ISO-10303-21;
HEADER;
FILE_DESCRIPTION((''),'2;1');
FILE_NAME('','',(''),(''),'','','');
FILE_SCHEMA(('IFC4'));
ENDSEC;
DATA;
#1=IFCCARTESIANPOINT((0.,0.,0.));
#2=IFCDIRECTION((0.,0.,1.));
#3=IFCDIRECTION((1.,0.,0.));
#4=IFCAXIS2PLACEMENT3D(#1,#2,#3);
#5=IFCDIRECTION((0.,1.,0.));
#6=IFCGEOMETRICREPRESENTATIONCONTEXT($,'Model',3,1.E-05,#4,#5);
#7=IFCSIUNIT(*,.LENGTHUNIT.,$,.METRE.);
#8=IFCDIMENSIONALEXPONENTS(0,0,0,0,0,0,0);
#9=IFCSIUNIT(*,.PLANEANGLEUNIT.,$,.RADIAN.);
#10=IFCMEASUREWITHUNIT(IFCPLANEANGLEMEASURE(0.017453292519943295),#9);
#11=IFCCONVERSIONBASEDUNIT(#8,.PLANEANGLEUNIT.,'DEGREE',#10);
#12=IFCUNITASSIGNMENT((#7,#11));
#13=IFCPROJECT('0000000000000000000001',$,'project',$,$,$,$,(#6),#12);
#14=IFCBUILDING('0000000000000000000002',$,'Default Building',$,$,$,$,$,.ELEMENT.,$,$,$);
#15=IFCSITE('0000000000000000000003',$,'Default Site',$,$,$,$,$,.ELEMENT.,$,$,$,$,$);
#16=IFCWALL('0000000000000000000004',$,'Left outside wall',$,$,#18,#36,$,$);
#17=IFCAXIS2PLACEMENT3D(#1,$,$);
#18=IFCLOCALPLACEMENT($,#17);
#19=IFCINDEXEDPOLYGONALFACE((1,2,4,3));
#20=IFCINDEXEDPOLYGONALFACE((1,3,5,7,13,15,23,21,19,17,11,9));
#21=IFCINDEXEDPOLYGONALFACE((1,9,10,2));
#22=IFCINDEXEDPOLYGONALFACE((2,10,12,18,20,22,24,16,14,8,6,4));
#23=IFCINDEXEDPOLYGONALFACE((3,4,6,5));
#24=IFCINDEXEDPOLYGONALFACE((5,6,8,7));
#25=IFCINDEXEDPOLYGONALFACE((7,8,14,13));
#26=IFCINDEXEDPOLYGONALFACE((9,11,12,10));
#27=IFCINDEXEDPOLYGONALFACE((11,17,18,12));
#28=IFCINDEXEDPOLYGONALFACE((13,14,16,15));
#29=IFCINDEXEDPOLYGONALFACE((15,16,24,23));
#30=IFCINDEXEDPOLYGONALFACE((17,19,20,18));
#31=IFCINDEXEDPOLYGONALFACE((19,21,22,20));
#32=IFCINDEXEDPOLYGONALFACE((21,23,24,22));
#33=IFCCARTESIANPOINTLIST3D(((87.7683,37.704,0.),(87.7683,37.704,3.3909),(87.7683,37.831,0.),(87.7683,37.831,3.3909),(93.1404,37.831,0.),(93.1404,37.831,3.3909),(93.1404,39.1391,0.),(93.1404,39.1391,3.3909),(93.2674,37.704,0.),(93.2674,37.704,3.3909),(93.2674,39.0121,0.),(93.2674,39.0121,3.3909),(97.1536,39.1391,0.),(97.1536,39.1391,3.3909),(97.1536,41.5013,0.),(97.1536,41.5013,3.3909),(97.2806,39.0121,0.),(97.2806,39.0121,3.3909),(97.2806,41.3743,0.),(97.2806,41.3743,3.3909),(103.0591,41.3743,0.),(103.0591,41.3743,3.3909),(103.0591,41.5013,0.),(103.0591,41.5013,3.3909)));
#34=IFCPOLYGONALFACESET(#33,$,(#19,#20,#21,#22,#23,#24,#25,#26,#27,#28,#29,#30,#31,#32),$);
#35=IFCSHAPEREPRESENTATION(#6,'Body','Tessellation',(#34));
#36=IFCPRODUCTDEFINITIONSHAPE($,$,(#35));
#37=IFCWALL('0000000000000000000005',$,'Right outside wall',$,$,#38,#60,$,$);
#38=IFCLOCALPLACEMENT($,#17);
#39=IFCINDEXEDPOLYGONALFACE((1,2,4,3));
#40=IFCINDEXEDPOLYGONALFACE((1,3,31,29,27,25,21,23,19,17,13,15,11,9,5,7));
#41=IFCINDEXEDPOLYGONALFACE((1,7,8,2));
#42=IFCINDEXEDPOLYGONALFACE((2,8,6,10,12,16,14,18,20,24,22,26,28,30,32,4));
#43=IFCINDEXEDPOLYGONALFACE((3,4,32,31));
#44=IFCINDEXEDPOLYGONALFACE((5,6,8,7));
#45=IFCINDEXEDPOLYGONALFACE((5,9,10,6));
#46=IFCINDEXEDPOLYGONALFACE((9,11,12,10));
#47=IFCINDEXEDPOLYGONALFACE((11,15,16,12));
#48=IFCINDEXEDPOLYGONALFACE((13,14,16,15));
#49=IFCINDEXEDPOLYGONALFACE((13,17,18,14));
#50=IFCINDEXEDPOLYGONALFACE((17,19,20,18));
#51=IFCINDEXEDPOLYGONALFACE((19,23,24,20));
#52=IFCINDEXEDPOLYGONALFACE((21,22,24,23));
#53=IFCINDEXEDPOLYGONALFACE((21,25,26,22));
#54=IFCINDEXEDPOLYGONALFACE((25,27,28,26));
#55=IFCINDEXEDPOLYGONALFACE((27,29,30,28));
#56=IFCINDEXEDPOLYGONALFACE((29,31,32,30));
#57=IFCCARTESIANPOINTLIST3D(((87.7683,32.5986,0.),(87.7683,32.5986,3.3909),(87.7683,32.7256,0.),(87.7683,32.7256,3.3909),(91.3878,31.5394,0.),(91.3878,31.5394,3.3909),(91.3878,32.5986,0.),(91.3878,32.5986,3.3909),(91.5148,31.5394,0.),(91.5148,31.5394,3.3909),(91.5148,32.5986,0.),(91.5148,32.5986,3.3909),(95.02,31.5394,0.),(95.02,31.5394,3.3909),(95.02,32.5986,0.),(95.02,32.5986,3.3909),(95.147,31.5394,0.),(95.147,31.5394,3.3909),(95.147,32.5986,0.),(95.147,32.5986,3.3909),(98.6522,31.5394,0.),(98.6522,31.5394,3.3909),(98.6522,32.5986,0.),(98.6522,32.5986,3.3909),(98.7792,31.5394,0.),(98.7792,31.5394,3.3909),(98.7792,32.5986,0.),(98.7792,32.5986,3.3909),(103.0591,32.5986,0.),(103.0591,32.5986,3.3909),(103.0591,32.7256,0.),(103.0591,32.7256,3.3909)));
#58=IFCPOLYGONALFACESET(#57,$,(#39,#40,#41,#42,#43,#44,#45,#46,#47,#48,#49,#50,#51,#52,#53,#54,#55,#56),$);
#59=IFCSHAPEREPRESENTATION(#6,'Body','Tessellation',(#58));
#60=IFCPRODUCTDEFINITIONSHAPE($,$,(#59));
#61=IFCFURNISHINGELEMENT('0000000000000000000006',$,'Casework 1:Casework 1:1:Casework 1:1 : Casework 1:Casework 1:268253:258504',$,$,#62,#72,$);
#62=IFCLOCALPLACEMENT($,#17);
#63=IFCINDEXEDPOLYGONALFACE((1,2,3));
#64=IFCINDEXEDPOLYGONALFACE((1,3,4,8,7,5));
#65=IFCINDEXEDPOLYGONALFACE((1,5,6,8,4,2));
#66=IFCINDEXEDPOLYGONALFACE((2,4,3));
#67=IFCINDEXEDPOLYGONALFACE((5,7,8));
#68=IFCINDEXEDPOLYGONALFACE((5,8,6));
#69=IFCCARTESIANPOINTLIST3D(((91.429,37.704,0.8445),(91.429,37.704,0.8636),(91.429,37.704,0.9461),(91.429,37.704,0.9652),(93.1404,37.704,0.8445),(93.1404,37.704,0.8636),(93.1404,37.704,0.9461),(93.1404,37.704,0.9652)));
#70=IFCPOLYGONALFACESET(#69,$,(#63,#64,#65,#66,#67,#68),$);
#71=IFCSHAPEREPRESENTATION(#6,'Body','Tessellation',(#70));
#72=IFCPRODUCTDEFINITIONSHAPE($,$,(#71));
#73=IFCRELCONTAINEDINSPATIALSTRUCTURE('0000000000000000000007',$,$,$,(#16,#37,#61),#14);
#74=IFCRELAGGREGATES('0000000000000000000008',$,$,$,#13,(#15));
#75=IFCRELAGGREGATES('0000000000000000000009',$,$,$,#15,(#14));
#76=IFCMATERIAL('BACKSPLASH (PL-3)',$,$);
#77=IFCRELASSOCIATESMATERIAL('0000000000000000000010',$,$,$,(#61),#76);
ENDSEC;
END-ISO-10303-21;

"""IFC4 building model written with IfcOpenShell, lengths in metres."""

from ifc_helpers import new_model, entity, si_unit, converted_unit, direction, frame, origin_with_axes, place, context, project, spatial, polyline, outline, extrude, material, element, save


model = new_model("IFC4")

# Units and contexts
model_context = context("Model", 3, precision=1e-05, world=origin_with_axes(), true_north=direction((0.0, 1.0, 0.0)))
ifc_project = project(units=[si_unit("LENGTHUNIT", "METRE"), converted_unit("PLANEANGLEUNIT", "DEGREE", entity("IfcPlaneAngleMeasure", 0.017453292519943295), si_unit("PLANEANGLEUNIT", "RADIAN"), dimensions=[0, 0, 0, 0, 0, 0, 0])], contexts=[model_context])

# Site, building
site = spatial("IfcSite", under=ifc_project, Name="Default Site", CompositionType="ELEMENT")
building = spatial("IfcBuilding", under=site, Name="Default Building", CompositionType="ELEMENT")

# Walls
wall_1_placement = place(None, origin_with_axes())
element("IfcWall", 1, at=wall_1_placement, inside=building, Name="Left outside wall", context=model_context, shape_type="SweptSolid", body=[
    extrude(outline(polyline([(87.7683, 37.831), (87.7683, 37.704), (93.2674, 37.704), (93.2674, 39.0121), (97.2806, 39.0121), (97.2806, 41.3743), (103.0591, 41.3743), (103.0591, 41.5013), (97.1536, 41.5013), (97.1536, 39.1391), (93.1404, 39.1391), (93.1404, 37.831), (87.7683, 37.831)])), origin_with_axes(), (0.0, 0.0, 1.0), 3.3909),
])
wall_2_placement = place(None, origin_with_axes())
element("IfcWall", 2, at=wall_2_placement, inside=building, Name="Right outside wall", context=model_context, shape_type="SweptSolid", body=[
    extrude(outline(polyline([(87.7683, 32.5986), (87.7683, 32.7256), (103.0591, 32.7256), (103.0591, 32.5986), (98.7792, 32.5986), (98.7792, 31.5394), (98.6522, 31.5394), (98.6522, 32.5986), (95.147, 32.5986), (95.147, 31.5394), (95.02, 31.5394), (95.02, 32.5986), (91.5148, 32.5986), (91.5148, 31.5394), (91.3878, 31.5394), (91.3878, 32.5986), (87.7683, 32.5986)])), origin_with_axes(), (0.0, 0.0, 1.0), 3.3909),
])

# Furnishing element
ifc_material_1 = material(Name="BACKSPLASH (PL-3)")
furnishing_1_placement = place(None, origin_with_axes())
element("IfcFurnishingElement", 3, at=furnishing_1_placement, inside=building, material=ifc_material_1, Name="Casework 1:Casework 1:1:Casework 1:1 : Casework 1:Casework 1:268253:258504", context=model_context, shape_type="SweptSolid", body=[
    extrude(outline(polyline([(0.8557, -0.0508), (0.8557, 0.0508), (-0.8557, 0.0508), (-0.8557, -0.0508), (0.8557, -0.0508)])), frame((92.2847, 37.704, 0.9144), z_axis=(0.0, -1.0, 0.0), x_axis=(1.0, 0.0, 0.0)), (0.0, -1.0, 0.0), 0.0191),
])

save(model, "model.ifc")
